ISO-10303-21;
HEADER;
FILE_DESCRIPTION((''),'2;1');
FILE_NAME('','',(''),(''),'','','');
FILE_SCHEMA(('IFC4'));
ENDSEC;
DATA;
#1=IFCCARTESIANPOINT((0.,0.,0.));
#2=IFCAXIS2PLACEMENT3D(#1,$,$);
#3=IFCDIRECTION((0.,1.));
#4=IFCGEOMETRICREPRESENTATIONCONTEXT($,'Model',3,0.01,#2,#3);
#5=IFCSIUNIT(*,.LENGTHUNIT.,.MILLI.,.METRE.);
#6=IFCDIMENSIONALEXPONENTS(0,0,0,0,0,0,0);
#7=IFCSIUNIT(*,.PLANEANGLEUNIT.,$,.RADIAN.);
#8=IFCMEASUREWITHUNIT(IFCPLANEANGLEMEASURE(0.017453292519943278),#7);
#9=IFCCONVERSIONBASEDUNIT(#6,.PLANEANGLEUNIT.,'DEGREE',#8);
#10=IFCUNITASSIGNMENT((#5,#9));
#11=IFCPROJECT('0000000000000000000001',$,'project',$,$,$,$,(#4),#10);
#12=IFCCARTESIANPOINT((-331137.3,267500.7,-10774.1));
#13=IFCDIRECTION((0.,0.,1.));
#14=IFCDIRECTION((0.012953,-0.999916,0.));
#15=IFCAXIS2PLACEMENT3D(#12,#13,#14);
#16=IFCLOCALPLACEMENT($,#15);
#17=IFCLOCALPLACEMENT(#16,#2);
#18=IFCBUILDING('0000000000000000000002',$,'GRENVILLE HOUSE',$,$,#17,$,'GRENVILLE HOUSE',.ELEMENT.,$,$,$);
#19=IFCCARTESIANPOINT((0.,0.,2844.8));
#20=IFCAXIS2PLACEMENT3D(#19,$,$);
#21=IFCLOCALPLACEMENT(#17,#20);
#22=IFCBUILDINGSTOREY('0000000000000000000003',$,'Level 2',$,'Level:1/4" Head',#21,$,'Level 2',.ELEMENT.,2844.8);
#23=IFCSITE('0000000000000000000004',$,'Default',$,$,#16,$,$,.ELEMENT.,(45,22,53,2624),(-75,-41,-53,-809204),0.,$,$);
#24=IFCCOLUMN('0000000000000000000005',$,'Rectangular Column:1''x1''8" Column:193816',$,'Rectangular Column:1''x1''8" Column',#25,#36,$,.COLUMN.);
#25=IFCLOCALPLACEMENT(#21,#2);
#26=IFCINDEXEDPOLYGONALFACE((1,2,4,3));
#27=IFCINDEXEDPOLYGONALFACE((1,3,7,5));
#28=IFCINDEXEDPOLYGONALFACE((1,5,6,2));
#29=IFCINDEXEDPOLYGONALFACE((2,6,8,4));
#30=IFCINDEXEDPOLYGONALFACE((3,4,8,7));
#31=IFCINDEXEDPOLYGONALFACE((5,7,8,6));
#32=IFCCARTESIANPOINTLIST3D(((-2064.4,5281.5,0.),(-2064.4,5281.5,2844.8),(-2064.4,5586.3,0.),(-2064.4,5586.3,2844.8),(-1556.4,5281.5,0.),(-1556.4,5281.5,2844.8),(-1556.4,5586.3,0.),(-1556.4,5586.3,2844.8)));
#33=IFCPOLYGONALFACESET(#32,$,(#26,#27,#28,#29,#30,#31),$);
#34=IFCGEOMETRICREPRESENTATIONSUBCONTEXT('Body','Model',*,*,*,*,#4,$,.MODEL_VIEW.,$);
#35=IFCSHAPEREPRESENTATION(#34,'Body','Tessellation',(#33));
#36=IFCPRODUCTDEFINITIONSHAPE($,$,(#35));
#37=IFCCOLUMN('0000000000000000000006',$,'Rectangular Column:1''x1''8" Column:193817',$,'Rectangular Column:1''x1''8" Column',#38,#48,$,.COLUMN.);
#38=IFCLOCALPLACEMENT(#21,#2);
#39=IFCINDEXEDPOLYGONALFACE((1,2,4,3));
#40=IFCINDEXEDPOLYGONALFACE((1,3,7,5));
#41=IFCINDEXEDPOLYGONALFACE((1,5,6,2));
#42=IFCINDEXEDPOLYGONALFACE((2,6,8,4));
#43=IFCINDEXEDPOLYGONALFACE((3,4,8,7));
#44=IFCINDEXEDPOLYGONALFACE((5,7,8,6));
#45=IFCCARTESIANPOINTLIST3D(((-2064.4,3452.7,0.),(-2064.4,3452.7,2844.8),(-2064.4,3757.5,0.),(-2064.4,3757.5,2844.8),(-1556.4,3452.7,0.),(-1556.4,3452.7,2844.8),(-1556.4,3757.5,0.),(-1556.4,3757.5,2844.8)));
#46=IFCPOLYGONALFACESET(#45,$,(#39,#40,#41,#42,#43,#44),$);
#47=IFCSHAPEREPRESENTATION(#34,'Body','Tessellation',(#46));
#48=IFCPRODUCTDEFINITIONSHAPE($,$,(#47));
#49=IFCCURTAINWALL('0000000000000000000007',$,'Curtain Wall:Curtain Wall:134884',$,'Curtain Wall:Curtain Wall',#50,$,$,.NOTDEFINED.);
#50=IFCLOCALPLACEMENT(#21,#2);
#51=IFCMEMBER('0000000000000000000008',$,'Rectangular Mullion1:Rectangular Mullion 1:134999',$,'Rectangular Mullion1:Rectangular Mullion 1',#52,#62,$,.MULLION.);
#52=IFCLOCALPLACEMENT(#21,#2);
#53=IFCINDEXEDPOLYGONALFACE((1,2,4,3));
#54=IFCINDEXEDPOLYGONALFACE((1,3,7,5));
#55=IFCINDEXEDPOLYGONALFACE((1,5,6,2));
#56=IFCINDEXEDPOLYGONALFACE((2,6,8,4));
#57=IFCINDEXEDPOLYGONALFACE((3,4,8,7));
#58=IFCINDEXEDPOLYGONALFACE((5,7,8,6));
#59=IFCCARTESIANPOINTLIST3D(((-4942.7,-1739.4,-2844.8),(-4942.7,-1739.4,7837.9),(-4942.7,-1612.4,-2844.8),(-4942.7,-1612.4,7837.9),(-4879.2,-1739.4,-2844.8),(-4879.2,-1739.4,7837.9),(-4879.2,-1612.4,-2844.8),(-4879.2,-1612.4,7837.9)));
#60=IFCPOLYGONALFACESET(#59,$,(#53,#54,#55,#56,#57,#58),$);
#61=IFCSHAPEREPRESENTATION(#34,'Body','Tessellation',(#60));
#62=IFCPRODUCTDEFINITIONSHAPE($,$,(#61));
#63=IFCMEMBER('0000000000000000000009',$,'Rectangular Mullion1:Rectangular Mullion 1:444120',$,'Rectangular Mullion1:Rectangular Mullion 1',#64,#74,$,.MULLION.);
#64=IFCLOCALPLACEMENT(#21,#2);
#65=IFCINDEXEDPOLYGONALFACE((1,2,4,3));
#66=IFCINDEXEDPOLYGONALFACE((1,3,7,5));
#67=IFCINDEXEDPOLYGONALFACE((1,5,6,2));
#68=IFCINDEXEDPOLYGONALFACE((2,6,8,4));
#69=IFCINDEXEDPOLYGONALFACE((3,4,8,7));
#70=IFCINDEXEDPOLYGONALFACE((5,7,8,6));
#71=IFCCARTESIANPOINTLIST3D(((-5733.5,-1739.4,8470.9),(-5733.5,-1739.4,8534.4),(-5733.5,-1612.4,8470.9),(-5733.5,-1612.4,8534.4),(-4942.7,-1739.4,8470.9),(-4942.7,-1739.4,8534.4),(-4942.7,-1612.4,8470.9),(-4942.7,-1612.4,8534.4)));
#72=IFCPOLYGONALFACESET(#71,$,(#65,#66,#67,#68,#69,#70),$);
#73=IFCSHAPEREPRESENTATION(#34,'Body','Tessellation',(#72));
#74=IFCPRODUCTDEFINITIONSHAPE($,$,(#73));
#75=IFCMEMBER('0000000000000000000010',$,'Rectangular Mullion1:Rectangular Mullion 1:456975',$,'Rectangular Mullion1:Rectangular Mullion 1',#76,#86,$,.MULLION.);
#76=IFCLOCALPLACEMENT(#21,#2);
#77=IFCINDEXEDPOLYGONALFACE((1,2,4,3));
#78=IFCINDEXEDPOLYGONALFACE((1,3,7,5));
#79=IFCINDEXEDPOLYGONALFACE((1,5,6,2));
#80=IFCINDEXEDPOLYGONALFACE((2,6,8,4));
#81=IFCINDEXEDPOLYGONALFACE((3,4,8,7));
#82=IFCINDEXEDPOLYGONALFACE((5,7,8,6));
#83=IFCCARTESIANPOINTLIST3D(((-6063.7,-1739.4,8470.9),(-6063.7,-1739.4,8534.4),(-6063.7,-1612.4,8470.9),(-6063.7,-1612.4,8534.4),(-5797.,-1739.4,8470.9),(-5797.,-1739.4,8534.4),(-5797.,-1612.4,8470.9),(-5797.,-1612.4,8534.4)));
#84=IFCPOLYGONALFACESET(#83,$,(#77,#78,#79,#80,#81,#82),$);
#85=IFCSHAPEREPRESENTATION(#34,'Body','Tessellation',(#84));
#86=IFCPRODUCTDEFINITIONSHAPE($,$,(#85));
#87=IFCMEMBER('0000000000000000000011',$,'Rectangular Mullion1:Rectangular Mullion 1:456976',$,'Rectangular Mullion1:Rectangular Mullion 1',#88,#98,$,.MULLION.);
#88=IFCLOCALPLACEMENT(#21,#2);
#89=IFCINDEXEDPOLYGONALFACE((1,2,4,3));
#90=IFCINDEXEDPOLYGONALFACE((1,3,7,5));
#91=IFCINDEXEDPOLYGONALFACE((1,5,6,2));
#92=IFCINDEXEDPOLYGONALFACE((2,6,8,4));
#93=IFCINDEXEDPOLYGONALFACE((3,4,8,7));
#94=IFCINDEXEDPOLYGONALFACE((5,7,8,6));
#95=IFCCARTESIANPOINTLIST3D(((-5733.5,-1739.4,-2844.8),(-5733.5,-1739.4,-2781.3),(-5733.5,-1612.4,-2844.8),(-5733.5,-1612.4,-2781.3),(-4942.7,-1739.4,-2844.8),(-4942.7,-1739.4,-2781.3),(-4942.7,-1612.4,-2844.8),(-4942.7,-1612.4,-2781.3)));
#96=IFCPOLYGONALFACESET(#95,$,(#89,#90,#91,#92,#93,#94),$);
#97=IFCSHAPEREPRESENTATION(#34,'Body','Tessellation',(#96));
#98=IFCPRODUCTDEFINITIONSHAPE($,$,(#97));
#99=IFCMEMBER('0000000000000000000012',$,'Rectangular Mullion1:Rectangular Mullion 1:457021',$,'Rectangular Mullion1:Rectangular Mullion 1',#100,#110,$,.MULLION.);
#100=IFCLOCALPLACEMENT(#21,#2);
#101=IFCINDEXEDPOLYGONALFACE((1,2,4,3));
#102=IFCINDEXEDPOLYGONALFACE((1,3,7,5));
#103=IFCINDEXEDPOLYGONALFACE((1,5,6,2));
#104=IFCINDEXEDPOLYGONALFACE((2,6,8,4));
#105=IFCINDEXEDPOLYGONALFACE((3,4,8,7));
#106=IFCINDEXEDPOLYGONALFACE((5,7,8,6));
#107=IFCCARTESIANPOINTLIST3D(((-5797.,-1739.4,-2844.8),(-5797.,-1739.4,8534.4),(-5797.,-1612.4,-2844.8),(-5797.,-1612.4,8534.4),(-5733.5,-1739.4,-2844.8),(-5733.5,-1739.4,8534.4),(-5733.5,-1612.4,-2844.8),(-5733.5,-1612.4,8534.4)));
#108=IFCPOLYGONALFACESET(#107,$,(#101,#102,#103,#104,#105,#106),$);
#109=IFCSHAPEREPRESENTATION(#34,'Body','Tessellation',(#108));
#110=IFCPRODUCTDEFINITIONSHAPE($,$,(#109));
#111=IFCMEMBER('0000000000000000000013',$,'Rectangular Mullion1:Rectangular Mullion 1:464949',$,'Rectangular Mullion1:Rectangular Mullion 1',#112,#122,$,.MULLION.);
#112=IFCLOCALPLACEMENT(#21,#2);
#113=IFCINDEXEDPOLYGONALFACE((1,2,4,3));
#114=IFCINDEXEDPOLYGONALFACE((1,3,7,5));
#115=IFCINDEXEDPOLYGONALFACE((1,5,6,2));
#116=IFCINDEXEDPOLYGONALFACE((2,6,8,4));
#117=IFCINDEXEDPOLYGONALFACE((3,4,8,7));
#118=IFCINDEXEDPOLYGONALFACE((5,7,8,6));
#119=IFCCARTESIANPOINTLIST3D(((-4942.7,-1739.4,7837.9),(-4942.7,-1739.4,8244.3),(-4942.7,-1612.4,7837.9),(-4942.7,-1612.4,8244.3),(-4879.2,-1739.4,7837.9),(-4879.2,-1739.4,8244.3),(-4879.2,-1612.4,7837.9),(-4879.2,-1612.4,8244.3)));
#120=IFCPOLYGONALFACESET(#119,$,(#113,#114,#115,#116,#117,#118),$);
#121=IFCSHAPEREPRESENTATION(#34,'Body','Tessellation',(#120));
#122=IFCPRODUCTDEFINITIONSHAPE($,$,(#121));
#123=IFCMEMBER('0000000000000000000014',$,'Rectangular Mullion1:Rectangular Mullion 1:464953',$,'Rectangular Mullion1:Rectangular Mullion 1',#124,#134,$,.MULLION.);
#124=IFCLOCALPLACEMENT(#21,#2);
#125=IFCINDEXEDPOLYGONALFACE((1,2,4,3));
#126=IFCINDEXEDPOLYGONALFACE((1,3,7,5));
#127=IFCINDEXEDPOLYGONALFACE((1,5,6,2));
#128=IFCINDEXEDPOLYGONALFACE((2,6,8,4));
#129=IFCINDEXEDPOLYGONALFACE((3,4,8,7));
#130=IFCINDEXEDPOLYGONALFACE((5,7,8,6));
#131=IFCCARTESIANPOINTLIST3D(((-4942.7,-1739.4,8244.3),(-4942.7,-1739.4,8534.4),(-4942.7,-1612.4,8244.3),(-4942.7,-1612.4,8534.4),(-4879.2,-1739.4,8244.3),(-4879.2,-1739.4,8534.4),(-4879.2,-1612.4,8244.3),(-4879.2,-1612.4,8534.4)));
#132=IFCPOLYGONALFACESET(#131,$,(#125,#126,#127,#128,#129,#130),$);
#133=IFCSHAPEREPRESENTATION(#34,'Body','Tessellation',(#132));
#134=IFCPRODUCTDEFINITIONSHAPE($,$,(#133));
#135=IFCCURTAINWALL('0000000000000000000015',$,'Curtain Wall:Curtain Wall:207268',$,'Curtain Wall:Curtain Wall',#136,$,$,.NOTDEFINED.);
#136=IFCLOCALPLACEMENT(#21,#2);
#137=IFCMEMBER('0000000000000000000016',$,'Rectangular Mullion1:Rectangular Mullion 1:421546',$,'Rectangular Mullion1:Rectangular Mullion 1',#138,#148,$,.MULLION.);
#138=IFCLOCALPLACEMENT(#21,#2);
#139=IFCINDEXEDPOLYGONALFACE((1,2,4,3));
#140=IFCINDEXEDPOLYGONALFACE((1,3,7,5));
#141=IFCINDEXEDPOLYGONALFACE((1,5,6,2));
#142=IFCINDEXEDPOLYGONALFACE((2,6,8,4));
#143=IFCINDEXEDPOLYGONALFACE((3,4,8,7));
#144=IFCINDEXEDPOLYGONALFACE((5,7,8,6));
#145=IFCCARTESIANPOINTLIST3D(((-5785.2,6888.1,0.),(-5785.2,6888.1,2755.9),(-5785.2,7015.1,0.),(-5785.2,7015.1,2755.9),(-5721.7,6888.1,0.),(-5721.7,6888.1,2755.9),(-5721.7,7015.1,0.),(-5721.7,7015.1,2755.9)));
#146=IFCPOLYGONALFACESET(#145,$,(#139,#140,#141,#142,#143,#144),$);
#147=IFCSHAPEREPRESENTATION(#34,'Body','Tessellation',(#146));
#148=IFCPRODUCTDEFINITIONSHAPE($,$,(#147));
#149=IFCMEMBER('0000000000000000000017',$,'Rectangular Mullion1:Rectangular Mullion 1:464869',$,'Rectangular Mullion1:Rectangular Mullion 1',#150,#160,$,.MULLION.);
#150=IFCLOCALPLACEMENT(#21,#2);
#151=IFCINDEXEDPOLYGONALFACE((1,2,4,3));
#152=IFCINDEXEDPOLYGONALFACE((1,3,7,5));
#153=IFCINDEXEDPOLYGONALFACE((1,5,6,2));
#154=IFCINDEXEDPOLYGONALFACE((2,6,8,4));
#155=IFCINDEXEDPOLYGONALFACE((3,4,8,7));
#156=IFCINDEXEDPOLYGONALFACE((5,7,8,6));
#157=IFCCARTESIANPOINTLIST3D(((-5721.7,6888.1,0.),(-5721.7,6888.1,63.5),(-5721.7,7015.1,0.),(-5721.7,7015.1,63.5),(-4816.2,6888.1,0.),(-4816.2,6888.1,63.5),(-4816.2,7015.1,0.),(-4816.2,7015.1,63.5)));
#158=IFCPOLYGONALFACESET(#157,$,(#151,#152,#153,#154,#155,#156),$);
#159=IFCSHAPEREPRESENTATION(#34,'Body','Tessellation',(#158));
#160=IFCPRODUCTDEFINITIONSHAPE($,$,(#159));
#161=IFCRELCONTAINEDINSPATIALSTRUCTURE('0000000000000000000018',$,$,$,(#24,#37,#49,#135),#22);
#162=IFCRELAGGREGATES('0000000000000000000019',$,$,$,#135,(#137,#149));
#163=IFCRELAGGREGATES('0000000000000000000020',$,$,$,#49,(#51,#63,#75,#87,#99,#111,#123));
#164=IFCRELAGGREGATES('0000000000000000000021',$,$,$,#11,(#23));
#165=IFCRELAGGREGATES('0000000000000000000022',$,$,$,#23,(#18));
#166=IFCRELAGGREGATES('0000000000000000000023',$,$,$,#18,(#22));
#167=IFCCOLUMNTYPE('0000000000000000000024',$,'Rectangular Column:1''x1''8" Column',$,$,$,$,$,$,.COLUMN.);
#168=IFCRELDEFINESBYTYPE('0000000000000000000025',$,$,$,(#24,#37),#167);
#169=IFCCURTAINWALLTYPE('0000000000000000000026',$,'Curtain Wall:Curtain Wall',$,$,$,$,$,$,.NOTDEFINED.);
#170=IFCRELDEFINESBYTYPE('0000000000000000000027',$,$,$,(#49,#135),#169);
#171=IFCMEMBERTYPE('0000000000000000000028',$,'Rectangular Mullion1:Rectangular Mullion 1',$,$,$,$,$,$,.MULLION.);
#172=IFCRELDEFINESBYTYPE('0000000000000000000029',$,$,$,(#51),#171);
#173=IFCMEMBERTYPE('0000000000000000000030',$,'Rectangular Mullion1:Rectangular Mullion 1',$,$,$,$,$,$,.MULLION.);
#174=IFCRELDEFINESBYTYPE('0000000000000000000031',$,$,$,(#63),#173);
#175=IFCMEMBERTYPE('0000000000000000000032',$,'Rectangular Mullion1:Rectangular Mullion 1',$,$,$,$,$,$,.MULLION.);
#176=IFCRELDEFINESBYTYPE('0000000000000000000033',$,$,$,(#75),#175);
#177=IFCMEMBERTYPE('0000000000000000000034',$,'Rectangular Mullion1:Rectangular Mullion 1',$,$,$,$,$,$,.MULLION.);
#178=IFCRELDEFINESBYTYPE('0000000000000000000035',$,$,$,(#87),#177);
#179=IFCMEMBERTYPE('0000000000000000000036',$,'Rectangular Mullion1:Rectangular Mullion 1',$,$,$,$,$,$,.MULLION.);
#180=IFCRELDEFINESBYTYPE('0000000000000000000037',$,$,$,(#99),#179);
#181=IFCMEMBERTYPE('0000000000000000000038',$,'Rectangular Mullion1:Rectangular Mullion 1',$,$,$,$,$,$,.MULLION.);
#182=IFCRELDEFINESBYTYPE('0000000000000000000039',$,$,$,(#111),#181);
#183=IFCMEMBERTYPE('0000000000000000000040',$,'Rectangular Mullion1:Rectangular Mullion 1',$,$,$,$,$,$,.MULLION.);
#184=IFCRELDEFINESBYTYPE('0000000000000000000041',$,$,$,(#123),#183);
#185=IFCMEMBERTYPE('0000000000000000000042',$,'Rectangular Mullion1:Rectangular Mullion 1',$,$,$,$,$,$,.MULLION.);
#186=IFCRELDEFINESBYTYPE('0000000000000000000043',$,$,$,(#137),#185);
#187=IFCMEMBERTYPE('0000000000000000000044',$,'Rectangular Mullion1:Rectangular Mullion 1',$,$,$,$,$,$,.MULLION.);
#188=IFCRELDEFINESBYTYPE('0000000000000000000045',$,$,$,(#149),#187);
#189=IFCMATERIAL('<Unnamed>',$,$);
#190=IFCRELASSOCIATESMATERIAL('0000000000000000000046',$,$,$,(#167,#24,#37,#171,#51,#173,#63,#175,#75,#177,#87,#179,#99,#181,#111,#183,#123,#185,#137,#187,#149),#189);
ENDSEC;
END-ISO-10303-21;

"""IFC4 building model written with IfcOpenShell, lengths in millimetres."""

from ifc_helpers import new_model, entity, si_unit, converted_unit, direction, frame, origin, place, context, subcontext, project, spatial, indexed_curve, outline, extrude, source, transform, mapped, material, type_object, type_shapes, element, aggregate, save


model = new_model("IFC4")

# Units and contexts
model_context = context("Model", 3, precision=0.01, world=origin(), true_north=direction((0.0, 1.0)))
body_context = subcontext(model_context, "Body", "Model", "MODEL_VIEW")
ifc_project = project(units=[si_unit("LENGTHUNIT", "METRE", prefix="MILLI"), converted_unit("PLANEANGLEUNIT", "DEGREE", entity("IfcPlaneAngleMeasure", 0.017453292519943278), si_unit("PLANEANGLEUNIT", "RADIAN"), dimensions=[0, 0, 0, 0, 0, 0, 0])], contexts=[model_context])

# Site, building, storey
site_placement = place(None, frame((-331137.3, 267500.7, -10774.1), z_axis=(0.0, 0.0, 1.0), x_axis=(0.012953, -0.999916, 0.0)))
site = spatial("IfcSite", under=ifc_project, at=site_placement, Name="Default", CompositionType="ELEMENT", RefLatitude=(45, 22, 53, 2624), RefLongitude=(-75, -41, -53, -809204), RefElevation=0.0)
building_placement = place(site_placement, origin())
building = spatial("IfcBuilding", under=site, at=building_placement, Name="GRENVILLE HOUSE", LongName="GRENVILLE HOUSE", CompositionType="ELEMENT")
storey_placement = place(building_placement, frame((0.0, 0.0, 2844.8)))
storey = spatial("IfcBuildingStorey", under=building, at=storey_placement, Name="Level 2", ObjectType="Level:1/4\" Head", LongName="Level 2", CompositionType="ELEMENT", Elevation=2844.8)

# Columns
ifc_material_1 = material(Name="<Unnamed>")
column_type = type_object("IfcColumnType", Name="Rectangular Column:1'x1'8\" Column", PredefinedType="COLUMN", material=ifc_material_1)
shared_shape_1 = source(origin(), body_context, "Body", "SweptSolid", [
    extrude(outline(indexed_curve([(-254.0, -152.4), (254.0, -152.4), (254.0, 152.4), (-254.0, 152.4), (-254.0, -152.4)], self_intersect=False)), frame((0.0, 0.0, 2844.8), z_axis=(0.0, 0.0, 1.0), x_axis=(-1.0, 0.0, 0.0)), (0.0, 0.0, 1.0), 2844.8),
])
type_shapes(column_type, [shared_shape_1])
for number, where, name in (
    (1, (-1810.4, 5433.9, -2844.8), "Rectangular Column:1'x1'8\" Column:193816"),
    (2, (-1810.4, 3605.1, -2844.8), "Rectangular Column:1'x1'8\" Column:193817"),
):
    element("IfcColumn", number, at=place(storey_placement, frame(where)), inside=storey, type_object=column_type, material=ifc_material_1, Name=name, ObjectType="Rectangular Column:1'x1'8\" Column", PredefinedType="COLUMN", context=body_context, shape_type="MappedRepresentation", body=[
        mapped(shared_shape_1, transform((0.0, 0.0, 0.0), scale=1.0)),
    ])

# Curtain walls, members
curtain_wall_type = type_object("IfcCurtainWallType", Name="Curtain Wall:Curtain Wall", PredefinedType="NOTDEFINED")
curtain_wall_1_placement = place(storey_placement, frame((0.0, 0.0, -2844.8)))
curtain_wall_1 = element("IfcCurtainWall", 3, at=curtain_wall_1_placement, inside=storey, type_object=curtain_wall_type, Name="Curtain Wall:Curtain Wall:134884", ObjectType="Curtain Wall:Curtain Wall", PredefinedType="NOTDEFINED")
member_type_1 = type_object("IfcMemberType", Name="Rectangular Mullion1:Rectangular Mullion 1", PredefinedType="MULLION", material=ifc_material_1)
shared_shape_2 = source(origin(), body_context, "Body", "SweptSolid", [
    extrude(outline(indexed_curve([(-31.8, -63.5), (31.8, -63.5), (31.8, 63.5), (-31.8, 63.5), (-31.8, -63.5)], self_intersect=False)), frame((-31.8, 0.0, -10682.7), z_axis=(0.0, 0.0, 1.0), x_axis=(-1.0, 0.0, 0.0)), (0.0, 0.0, 1.0), 10682.7),
])
type_shapes(member_type_1, [shared_shape_2])
member_1_placement = place(curtain_wall_1_placement, frame((-4879.2, -1675.9, 0.0), z_axis=(0.0, 0.0, -1.0), x_axis=(1.0, 0.0, 0.0)))
member_1 = element("IfcMember", 4, at=member_1_placement, type_object=member_type_1, material=ifc_material_1, Name="Rectangular Mullion1:Rectangular Mullion 1:134999", ObjectType="Rectangular Mullion1:Rectangular Mullion 1", PredefinedType="MULLION", context=body_context, shape_type="MappedRepresentation", body=[
    mapped(shared_shape_2, transform((0.0, 0.0, 0.0), scale=1.0)),
])
member_type_2 = type_object("IfcMemberType", Name="Rectangular Mullion1:Rectangular Mullion 1", PredefinedType="MULLION", material=ifc_material_1)
shared_shape_3 = source(origin(), body_context, "Body", "SweptSolid", [
    extrude(outline(indexed_curve([(-31.8, -63.5), (31.8, -63.5), (31.8, 63.5), (-31.8, 63.5), (-31.8, -63.5)], self_intersect=False)), frame((-31.8, 0.0, -790.8), z_axis=(0.0, 0.0, 1.0), x_axis=(-1.0, 0.0, 0.0)), (0.0, 0.0, 1.0), 790.8),
])
type_shapes(member_type_2, [shared_shape_3])
member_2_placement = place(curtain_wall_1_placement, frame((-4942.7, -1675.9, 11379.2), z_axis=(1.0, 0.0, 0.0), x_axis=(0.0, 0.0, 1.0)))
member_2 = element("IfcMember", 5, at=member_2_placement, type_object=member_type_2, material=ifc_material_1, Name="Rectangular Mullion1:Rectangular Mullion 1:444120", ObjectType="Rectangular Mullion1:Rectangular Mullion 1", PredefinedType="MULLION", context=body_context, shape_type="MappedRepresentation", body=[
    mapped(shared_shape_3, transform((0.0, 0.0, 0.0), scale=1.0)),
])
member_type_3 = type_object("IfcMemberType", Name="Rectangular Mullion1:Rectangular Mullion 1", PredefinedType="MULLION", material=ifc_material_1)
shared_shape_4 = source(origin(), body_context, "Body", "SweptSolid", [
    extrude(outline(indexed_curve([(-31.8, -63.5), (31.8, -63.5), (31.8, 63.5), (-31.8, 63.5), (-31.8, -63.5)], self_intersect=False)), frame((-31.8, 0.0, -266.7), z_axis=(0.0, 0.0, 1.0), x_axis=(-1.0, 0.0, 0.0)), (0.0, 0.0, 1.0), 266.7),
])
type_shapes(member_type_3, [shared_shape_4])
member_3_placement = place(curtain_wall_1_placement, frame((-5797.0, -1675.9, 11379.2), z_axis=(1.0, 0.0, 0.0), x_axis=(0.0, 0.0, 1.0)))
member_3 = element("IfcMember", 6, at=member_3_placement, type_object=member_type_3, material=ifc_material_1, Name="Rectangular Mullion1:Rectangular Mullion 1:456975", ObjectType="Rectangular Mullion1:Rectangular Mullion 1", PredefinedType="MULLION", context=body_context, shape_type="MappedRepresentation", body=[
    mapped(shared_shape_4, transform((0.0, 0.0, 0.0), scale=1.0)),
])
member_type_4 = type_object("IfcMemberType", Name="Rectangular Mullion1:Rectangular Mullion 1", PredefinedType="MULLION", material=ifc_material_1)
shared_shape_5 = source(origin(), body_context, "Body", "SweptSolid", [
    extrude(outline(indexed_curve([(-31.8, -63.5), (31.8, -63.5), (31.8, 63.5), (-31.8, 63.5), (-31.8, -63.5)], self_intersect=False)), frame((-31.8, 0.0, -790.8), z_axis=(0.0, 0.0, 1.0), x_axis=(-1.0, 0.0, 0.0)), (0.0, 0.0, 1.0), 790.8),
])
type_shapes(member_type_4, [shared_shape_5])
member_4_placement = place(curtain_wall_1_placement, frame((-5733.5, -1675.9, 0.0), z_axis=(-1.0, 0.0, 0.0), x_axis=(0.0, 0.0, -1.0)))
member_4 = element("IfcMember", 7, at=member_4_placement, type_object=member_type_4, material=ifc_material_1, Name="Rectangular Mullion1:Rectangular Mullion 1:456976", ObjectType="Rectangular Mullion1:Rectangular Mullion 1", PredefinedType="MULLION", context=body_context, shape_type="MappedRepresentation", body=[
    mapped(shared_shape_5, transform((0.0, 0.0, 0.0), scale=1.0)),
])
member_type_5 = type_object("IfcMemberType", Name="Rectangular Mullion1:Rectangular Mullion 1", PredefinedType="MULLION", material=ifc_material_1)
shared_shape_6 = source(origin(), body_context, "Body", "SweptSolid", [
    extrude(outline(indexed_curve([(-31.8, -63.5), (31.8, -63.5), (31.8, 63.5), (-31.8, 63.5), (-31.8, -63.5)], self_intersect=False)), frame((0.0, 0.0, -11379.2), z_axis=(0.0, 0.0, 1.0), x_axis=(-1.0, 0.0, 0.0)), (0.0, 0.0, 1.0), 11379.2),
])
type_shapes(member_type_5, [shared_shape_6])
member_5_placement = place(curtain_wall_1_placement, frame((-5765.2, -1675.9, 0.0), z_axis=(0.0, 0.0, -1.0), x_axis=(1.0, 0.0, 0.0)))
member_5 = element("IfcMember", 8, at=member_5_placement, type_object=member_type_5, material=ifc_material_1, Name="Rectangular Mullion1:Rectangular Mullion 1:457021", ObjectType="Rectangular Mullion1:Rectangular Mullion 1", PredefinedType="MULLION", context=body_context, shape_type="MappedRepresentation", body=[
    mapped(shared_shape_6, transform((0.0, 0.0, 0.0), scale=1.0)),
])
member_type_6 = type_object("IfcMemberType", Name="Rectangular Mullion1:Rectangular Mullion 1", PredefinedType="MULLION", material=ifc_material_1)
shared_shape_7 = source(origin(), body_context, "Body", "SweptSolid", [
    extrude(outline(indexed_curve([(-31.8, -63.5), (31.8, -63.5), (31.8, 63.5), (-31.8, 63.5), (-31.8, -63.5)], self_intersect=False)), frame((-31.8, 0.0, -406.4), z_axis=(0.0, 0.0, 1.0), x_axis=(-1.0, 0.0, 0.0)), (0.0, 0.0, 1.0), 406.4),
])
type_shapes(member_type_6, [shared_shape_7])
member_6_placement = place(curtain_wall_1_placement, frame((-4879.2, -1675.9, 10682.7), z_axis=(0.0, 0.0, -1.0), x_axis=(1.0, 0.0, 0.0)))
member_6 = element("IfcMember", 9, at=member_6_placement, type_object=member_type_6, material=ifc_material_1, Name="Rectangular Mullion1:Rectangular Mullion 1:464949", ObjectType="Rectangular Mullion1:Rectangular Mullion 1", PredefinedType="MULLION", context=body_context, shape_type="MappedRepresentation", body=[
    mapped(shared_shape_7, transform((0.0, 0.0, 0.0), scale=1.0)),
])
member_type_7 = type_object("IfcMemberType", Name="Rectangular Mullion1:Rectangular Mullion 1", PredefinedType="MULLION", material=ifc_material_1)
shared_shape_8 = source(origin(), body_context, "Body", "SweptSolid", [
    extrude(outline(indexed_curve([(-31.8, -63.5), (31.8, -63.5), (31.8, 63.5), (-31.8, 63.5), (-31.8, -63.5)], self_intersect=False)), frame((-31.8, 0.0, -290.1), z_axis=(0.0, 0.0, 1.0), x_axis=(-1.0, 0.0, 0.0)), (0.0, 0.0, 1.0), 290.1),
])
type_shapes(member_type_7, [shared_shape_8])
member_7_placement = place(curtain_wall_1_placement, frame((-4879.2, -1675.9, 11089.1), z_axis=(0.0, 0.0, -1.0), x_axis=(1.0, 0.0, 0.0)))
member_7 = element("IfcMember", 10, at=member_7_placement, type_object=member_type_7, material=ifc_material_1, Name="Rectangular Mullion1:Rectangular Mullion 1:464953", ObjectType="Rectangular Mullion1:Rectangular Mullion 1", PredefinedType="MULLION", context=body_context, shape_type="MappedRepresentation", body=[
    mapped(shared_shape_8, transform((0.0, 0.0, 0.0), scale=1.0)),
])
curtain_wall_2_placement = place(storey_placement, frame((0.0, 0.0, -2844.8)))
curtain_wall_2 = element("IfcCurtainWall", 11, at=curtain_wall_2_placement, inside=storey, type_object=curtain_wall_type, Name="Curtain Wall:Curtain Wall:207268", ObjectType="Curtain Wall:Curtain Wall", PredefinedType="NOTDEFINED")
member_type_8 = type_object("IfcMemberType", Name="Rectangular Mullion1:Rectangular Mullion 1", PredefinedType="MULLION", material=ifc_material_1)
shared_shape_9 = source(origin(), body_context, "Body", "SweptSolid", [
    extrude(outline(indexed_curve([(-31.8, -63.5), (31.8, -63.5), (31.8, 63.5), (-31.8, 63.5), (-31.8, -63.5)], self_intersect=False)), frame((0.0, 0.0, -2755.9), z_axis=(0.0, 0.0, 1.0), x_axis=(-1.0, 0.0, 0.0)), (0.0, 0.0, 1.0), 2755.9),
])
type_shapes(member_type_8, [shared_shape_9])
member_8_placement = place(curtain_wall_2_placement, frame((-5753.4, 6951.6, 2844.8), z_axis=(0.0, 0.0, -1.0), x_axis=(-1.0, 0.0, 0.0)))
member_8 = element("IfcMember", 12, at=member_8_placement, type_object=member_type_8, material=ifc_material_1, Name="Rectangular Mullion1:Rectangular Mullion 1:421546", ObjectType="Rectangular Mullion1:Rectangular Mullion 1", PredefinedType="MULLION", context=body_context, shape_type="MappedRepresentation", body=[
    mapped(shared_shape_9, transform((0.0, 0.0, 0.0), scale=1.0)),
])
member_type_9 = type_object("IfcMemberType", Name="Rectangular Mullion1:Rectangular Mullion 1", PredefinedType="MULLION", material=ifc_material_1)
shared_shape_10 = source(origin(), body_context, "Body", "SweptSolid", [
    extrude(outline(indexed_curve([(-31.8, -63.5), (31.8, -63.5), (31.8, 63.5), (-31.8, 63.5), (-31.8, -63.5)], self_intersect=False)), frame((-31.8, 0.0, -905.5), z_axis=(0.0, 0.0, 1.0), x_axis=(-1.0, 0.0, 0.0)), (0.0, 0.0, 1.0), 905.5),
])
type_shapes(member_type_9, [shared_shape_10])
member_9_placement = place(curtain_wall_2_placement, frame((-4816.2, 6951.6, 2844.8), z_axis=(1.0, 0.0, 0.0), x_axis=(0.0, 0.0, -1.0)))
member_9 = element("IfcMember", 13, at=member_9_placement, type_object=member_type_9, material=ifc_material_1, Name="Rectangular Mullion1:Rectangular Mullion 1:464869", ObjectType="Rectangular Mullion1:Rectangular Mullion 1", PredefinedType="MULLION", context=body_context, shape_type="MappedRepresentation", body=[
    mapped(shared_shape_10, transform((0.0, 0.0, 0.0), scale=1.0)),
])

aggregate(curtain_wall_2, [member_8, member_9])

aggregate(curtain_wall_1, [member_1, member_2, member_3, member_4, member_5, member_6, member_7])

save(model, "model.ifc")
